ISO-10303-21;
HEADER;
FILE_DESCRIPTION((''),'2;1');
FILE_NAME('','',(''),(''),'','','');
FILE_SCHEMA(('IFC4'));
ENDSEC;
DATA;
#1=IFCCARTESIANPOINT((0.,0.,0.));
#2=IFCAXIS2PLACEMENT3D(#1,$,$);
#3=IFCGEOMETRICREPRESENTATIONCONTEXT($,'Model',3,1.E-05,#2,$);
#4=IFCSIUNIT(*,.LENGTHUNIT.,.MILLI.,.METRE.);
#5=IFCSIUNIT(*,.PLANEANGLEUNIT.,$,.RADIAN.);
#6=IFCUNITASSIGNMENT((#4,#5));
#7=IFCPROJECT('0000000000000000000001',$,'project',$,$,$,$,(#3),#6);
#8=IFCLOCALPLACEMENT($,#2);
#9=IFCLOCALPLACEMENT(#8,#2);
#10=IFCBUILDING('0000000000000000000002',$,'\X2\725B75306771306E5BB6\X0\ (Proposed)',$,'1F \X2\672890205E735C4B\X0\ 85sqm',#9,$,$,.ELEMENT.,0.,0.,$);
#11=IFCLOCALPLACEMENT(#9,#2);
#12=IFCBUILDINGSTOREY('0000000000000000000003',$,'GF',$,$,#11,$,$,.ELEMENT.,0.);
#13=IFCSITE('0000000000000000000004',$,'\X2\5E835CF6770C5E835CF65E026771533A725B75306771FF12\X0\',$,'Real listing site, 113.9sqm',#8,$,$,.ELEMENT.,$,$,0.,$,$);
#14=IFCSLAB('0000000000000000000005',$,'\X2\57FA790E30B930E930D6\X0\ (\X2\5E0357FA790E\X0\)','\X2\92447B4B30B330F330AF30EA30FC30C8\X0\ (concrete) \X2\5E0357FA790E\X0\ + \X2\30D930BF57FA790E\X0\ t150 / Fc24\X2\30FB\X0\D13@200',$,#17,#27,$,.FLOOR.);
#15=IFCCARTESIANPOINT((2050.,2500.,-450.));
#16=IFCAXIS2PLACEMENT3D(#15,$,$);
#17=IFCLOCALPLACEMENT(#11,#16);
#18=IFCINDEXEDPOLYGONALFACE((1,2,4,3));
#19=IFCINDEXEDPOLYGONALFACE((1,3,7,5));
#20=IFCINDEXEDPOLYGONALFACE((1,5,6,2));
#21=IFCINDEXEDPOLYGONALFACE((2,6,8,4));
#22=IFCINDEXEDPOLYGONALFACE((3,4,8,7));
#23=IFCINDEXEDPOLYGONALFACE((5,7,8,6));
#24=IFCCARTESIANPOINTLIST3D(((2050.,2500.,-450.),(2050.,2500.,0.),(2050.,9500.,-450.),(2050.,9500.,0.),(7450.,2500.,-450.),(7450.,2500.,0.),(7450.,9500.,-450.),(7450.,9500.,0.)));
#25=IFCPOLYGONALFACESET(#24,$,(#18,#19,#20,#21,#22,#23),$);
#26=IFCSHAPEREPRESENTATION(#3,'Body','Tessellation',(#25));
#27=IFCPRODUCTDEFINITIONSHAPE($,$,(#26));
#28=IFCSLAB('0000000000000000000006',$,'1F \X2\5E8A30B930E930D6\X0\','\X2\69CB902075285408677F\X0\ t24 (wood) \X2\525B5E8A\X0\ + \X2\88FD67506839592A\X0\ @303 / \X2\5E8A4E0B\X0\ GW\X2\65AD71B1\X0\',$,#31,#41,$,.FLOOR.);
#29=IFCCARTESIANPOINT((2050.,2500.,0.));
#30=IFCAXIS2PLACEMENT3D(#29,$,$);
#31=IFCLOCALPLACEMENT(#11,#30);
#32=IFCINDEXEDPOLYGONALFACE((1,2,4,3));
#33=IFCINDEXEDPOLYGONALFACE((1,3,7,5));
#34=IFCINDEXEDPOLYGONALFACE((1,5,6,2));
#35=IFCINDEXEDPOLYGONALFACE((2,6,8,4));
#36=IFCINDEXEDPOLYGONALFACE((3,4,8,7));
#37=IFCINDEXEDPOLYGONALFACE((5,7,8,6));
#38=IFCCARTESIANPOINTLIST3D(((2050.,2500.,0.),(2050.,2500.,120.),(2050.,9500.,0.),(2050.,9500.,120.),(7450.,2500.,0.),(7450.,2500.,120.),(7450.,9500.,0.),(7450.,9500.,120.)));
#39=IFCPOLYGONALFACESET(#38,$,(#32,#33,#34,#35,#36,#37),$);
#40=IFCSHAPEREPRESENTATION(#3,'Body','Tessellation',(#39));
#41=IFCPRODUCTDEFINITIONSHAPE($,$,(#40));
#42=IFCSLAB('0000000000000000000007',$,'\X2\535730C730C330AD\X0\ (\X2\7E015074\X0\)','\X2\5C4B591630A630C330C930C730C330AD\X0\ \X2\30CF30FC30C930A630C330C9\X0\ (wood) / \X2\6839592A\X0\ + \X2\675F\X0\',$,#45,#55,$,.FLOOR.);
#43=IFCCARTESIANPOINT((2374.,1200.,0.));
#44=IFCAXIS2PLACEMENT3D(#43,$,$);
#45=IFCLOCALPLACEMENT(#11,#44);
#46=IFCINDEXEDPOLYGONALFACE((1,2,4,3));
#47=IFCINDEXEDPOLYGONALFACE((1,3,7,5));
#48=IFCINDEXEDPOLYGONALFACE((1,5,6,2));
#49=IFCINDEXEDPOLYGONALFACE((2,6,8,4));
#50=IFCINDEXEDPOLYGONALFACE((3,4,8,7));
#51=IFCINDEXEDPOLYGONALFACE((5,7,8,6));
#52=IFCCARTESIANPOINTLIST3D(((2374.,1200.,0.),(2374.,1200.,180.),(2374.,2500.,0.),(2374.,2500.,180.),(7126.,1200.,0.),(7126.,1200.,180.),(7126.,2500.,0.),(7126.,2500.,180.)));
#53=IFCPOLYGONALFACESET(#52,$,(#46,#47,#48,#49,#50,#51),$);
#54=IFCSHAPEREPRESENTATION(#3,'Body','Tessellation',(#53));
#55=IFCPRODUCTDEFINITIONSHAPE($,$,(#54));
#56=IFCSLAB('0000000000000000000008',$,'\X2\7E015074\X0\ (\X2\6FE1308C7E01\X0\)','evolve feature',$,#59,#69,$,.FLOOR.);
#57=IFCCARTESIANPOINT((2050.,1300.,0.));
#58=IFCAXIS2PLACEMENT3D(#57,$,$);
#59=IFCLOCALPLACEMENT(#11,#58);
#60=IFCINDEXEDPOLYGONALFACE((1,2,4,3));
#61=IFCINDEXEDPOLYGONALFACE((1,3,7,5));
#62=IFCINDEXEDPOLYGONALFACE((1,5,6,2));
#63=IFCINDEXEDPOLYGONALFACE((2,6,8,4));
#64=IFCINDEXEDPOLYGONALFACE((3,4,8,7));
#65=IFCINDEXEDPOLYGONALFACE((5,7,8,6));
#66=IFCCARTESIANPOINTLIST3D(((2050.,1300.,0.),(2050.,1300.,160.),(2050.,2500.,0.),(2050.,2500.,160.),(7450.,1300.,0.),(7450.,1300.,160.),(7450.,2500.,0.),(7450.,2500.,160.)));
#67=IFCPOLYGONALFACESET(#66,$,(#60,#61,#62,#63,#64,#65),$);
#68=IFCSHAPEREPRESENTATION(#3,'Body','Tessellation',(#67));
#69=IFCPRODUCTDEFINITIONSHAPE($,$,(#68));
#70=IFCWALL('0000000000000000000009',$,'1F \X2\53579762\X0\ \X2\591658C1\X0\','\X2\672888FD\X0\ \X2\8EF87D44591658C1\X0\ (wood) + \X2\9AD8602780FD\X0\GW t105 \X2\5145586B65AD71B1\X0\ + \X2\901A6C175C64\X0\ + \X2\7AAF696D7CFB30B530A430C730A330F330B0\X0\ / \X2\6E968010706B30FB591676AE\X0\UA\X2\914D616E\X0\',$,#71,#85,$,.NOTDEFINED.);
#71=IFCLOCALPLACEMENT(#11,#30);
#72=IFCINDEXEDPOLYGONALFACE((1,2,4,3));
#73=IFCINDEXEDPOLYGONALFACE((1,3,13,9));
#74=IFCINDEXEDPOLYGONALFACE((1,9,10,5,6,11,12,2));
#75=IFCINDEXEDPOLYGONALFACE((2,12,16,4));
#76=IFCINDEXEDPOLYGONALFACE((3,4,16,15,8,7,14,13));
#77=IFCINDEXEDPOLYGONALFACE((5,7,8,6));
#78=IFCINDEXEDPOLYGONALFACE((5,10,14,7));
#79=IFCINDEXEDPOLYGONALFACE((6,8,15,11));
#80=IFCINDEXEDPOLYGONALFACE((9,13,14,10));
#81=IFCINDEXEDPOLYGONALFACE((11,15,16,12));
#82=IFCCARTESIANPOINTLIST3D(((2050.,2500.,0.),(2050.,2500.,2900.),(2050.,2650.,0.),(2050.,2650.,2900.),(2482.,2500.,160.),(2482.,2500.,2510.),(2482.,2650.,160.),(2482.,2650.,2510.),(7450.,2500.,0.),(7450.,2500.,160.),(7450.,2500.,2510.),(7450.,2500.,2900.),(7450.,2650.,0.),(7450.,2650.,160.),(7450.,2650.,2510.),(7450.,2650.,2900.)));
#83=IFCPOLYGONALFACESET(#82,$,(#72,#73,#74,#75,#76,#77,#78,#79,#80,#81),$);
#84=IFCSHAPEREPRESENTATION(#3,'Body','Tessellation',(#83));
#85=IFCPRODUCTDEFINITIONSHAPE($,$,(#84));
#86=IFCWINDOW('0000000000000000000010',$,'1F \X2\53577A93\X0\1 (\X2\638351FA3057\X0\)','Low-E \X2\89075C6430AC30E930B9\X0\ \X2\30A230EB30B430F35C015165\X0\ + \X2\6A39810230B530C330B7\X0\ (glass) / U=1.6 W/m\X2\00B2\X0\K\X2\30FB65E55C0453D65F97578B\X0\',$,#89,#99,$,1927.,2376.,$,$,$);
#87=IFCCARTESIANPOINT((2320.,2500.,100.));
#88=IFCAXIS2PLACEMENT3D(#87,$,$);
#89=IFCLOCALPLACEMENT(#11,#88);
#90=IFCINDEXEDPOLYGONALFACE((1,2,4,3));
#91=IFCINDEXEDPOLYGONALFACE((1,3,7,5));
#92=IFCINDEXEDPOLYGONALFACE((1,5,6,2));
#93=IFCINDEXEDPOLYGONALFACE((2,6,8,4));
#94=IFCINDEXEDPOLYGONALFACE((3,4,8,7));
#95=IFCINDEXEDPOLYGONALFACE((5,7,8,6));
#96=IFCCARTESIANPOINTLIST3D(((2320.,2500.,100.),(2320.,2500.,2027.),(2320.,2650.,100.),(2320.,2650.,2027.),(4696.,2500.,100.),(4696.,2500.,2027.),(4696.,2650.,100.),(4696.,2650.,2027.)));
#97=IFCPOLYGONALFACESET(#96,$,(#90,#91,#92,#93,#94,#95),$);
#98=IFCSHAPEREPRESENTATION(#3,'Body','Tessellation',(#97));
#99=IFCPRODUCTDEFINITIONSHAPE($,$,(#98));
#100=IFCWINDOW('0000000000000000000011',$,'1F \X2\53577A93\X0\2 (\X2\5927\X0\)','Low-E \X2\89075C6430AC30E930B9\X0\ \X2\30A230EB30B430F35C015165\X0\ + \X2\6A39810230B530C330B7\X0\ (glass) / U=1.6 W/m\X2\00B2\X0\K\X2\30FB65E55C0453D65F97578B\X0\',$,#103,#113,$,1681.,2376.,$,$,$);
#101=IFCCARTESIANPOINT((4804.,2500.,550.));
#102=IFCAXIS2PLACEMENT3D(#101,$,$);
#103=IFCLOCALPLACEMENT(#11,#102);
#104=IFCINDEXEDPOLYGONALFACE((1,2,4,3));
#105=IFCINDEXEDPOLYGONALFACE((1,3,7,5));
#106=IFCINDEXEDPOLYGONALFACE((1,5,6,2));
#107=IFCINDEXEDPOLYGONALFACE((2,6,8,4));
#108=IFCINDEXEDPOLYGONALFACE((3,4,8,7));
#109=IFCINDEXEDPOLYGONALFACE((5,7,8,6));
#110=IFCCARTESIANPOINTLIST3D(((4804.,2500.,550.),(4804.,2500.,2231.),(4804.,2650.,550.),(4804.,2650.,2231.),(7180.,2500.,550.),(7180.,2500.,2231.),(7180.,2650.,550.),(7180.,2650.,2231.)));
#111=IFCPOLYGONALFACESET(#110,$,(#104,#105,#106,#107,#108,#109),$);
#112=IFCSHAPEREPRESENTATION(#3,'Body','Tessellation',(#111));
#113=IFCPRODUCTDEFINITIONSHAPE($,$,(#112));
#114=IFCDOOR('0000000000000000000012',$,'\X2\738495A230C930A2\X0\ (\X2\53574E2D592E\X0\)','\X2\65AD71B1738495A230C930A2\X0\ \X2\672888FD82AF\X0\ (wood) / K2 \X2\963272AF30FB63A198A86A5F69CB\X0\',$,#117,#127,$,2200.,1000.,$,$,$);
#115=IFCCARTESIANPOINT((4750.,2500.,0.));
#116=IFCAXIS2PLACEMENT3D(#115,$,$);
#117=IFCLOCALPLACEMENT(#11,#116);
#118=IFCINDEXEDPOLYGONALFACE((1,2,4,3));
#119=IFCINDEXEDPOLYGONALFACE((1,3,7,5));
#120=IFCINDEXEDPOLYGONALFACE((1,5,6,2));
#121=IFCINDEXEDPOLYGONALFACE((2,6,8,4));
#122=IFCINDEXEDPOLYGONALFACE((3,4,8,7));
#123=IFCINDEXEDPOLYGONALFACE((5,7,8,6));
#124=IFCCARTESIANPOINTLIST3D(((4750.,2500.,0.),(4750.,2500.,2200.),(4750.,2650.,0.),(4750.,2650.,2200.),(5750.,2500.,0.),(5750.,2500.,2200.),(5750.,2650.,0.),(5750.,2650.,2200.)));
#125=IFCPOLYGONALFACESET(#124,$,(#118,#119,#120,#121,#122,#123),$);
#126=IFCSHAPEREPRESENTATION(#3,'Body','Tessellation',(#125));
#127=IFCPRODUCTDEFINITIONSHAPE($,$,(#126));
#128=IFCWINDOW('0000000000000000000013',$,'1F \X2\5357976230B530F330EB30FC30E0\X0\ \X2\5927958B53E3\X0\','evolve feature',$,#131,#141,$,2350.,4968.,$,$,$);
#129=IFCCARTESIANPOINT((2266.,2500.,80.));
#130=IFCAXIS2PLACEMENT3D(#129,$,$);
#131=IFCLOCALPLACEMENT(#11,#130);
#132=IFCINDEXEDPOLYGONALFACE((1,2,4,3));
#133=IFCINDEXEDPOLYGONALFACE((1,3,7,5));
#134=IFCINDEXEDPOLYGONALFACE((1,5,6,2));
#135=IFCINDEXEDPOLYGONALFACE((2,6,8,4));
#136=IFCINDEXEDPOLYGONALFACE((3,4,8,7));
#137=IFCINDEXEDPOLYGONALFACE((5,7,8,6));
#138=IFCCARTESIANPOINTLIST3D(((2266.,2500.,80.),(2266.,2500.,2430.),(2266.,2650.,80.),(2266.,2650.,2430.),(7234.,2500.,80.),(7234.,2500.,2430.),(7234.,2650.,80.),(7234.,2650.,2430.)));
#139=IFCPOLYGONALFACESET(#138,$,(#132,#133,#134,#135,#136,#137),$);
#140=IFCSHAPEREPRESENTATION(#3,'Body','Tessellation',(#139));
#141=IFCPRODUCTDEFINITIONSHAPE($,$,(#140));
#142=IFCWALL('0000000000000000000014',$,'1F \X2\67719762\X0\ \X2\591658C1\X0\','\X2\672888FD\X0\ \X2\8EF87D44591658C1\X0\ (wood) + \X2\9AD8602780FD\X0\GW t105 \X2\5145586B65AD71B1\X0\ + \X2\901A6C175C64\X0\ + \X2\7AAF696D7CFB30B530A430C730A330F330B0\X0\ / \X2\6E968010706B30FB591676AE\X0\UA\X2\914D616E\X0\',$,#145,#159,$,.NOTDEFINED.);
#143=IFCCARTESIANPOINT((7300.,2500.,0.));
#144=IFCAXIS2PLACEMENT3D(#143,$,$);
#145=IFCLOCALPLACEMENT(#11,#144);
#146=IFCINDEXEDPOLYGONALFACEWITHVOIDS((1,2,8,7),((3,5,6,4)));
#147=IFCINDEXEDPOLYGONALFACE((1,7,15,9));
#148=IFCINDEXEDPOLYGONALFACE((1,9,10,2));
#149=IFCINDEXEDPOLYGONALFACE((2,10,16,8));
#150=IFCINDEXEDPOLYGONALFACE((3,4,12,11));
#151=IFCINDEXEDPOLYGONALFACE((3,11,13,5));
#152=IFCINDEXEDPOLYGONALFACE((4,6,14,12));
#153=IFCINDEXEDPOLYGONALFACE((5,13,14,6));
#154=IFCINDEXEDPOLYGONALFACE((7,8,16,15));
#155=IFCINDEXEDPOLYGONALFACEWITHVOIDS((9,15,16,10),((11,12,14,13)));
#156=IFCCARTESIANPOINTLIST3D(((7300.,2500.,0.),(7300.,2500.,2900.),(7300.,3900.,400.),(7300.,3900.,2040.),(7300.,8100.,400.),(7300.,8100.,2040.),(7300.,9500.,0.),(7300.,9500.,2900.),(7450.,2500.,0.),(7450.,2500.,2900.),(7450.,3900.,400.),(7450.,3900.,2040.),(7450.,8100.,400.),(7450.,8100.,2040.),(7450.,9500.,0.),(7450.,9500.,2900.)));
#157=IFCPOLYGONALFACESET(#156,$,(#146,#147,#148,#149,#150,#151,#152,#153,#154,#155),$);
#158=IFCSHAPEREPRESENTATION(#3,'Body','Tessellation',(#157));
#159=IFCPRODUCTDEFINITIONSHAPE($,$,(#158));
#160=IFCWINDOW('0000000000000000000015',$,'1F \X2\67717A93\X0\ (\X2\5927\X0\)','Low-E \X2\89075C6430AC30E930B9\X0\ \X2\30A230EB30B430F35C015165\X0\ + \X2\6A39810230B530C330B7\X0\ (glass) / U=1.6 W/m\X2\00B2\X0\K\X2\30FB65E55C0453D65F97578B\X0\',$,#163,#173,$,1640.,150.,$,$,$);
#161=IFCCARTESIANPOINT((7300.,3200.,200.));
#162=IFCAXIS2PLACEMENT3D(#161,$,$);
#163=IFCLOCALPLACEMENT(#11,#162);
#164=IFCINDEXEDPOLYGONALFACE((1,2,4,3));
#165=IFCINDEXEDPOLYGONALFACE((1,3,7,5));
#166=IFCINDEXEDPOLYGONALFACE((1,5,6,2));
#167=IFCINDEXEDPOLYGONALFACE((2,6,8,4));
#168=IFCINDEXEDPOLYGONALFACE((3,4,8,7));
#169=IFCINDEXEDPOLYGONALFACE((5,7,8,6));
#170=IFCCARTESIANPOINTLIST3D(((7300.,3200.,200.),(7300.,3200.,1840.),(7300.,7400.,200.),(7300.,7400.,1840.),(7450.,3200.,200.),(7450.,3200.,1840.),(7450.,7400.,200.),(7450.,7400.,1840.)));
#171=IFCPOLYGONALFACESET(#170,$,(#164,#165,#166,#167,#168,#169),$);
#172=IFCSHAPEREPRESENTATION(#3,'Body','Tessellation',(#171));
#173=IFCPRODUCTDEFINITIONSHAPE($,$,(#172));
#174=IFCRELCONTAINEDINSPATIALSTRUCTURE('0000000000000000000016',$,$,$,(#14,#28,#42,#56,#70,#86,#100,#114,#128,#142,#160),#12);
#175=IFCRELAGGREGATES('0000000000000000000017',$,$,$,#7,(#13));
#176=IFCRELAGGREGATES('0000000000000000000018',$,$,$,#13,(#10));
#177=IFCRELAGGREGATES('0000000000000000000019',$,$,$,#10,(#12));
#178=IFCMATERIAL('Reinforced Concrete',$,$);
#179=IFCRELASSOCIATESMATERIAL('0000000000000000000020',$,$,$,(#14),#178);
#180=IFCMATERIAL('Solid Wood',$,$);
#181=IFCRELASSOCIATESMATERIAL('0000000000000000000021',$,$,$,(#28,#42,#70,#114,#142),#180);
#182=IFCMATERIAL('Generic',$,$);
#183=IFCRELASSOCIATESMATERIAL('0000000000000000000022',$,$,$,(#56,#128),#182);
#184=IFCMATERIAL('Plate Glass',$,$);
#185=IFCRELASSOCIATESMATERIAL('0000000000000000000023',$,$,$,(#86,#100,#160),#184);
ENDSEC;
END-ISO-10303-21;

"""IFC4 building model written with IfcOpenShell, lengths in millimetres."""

from ifc_helpers import new_model, si_unit, frame, frame_2d, origin, place, context, project, spatial, rectangle, extrude, material, element, fill, save


model = new_model("IFC4")

# Units and contexts
model_context = context("Model", 3, precision=1e-05, world=origin())
ifc_project = project(units=[si_unit("LENGTHUNIT", "METRE", prefix="MILLI"), si_unit("PLANEANGLEUNIT", "RADIAN")], contexts=[model_context])

# Site, building, storey
site_placement = place(None, origin())
site = spatial("IfcSite", under=ifc_project, at=site_placement, Name="広島県広島市東区牛田東２", ObjectType="Real listing site, 113.9sqm", CompositionType="ELEMENT", RefElevation=0.0)
building_placement = place(site_placement, origin())
building = spatial("IfcBuilding", under=site, at=building_placement, Name="牛田東の家 (Proposed)", ObjectType="1F 木造平屋 85sqm", CompositionType="ELEMENT", ElevationOfRefHeight=0.0, ElevationOfTerrain=0.0)
storey_placement = place(building_placement, origin())
storey = spatial("IfcBuildingStorey", under=building, at=storey_placement, Name="GF", CompositionType="ELEMENT", Elevation=0.0)

# Slabs
ifc_material_1 = material(Name="Reinforced Concrete")
slab_1_placement = place(storey_placement, frame((2050.0, 2500.0, -450.0)))
element("IfcSlab", 1, at=slab_1_placement, inside=storey, material=ifc_material_1, Name="基礎スラブ (布基礎)", Description="鉄筋コンクリート (concrete) 布基礎 + ベタ基礎 t150 / Fc24・D13@200", PredefinedType="FLOOR", context=model_context, shape_type="SweptSolid", body=[
    extrude(rectangle(XDim=5400.0, YDim=7000.0, at=frame_2d((2700.0, 3500.0))), frame((2050.0, 2500.0, -450.0)), (0.0, 0.0, 1.0), 450.0),
])
ifc_material_2 = material(Name="Solid Wood")
slab_2_placement = place(storey_placement, frame((2050.0, 2500.0, 0.0)))
element("IfcSlab", 2, at=slab_2_placement, inside=storey, material=ifc_material_2, Name="1F 床スラブ", Description="構造用合板 t24 (wood) 剛床 + 製材根太 @303 / 床下 GW断熱", PredefinedType="FLOOR", context=model_context, shape_type="SweptSolid", body=[
    extrude(rectangle(XDim=5400.0, YDim=7000.0, at=frame_2d((2700.0, 3500.0))), frame((2050.0, 2500.0, 0.0)), (0.0, 0.0, 1.0), 120.0),
])
slab_3_placement = place(storey_placement, frame((2374.0, 1200.0, 0.0)))
element("IfcSlab", 3, at=slab_3_placement, inside=storey, material=ifc_material_2, Name="南デッキ (縁側)", Description="屋外ウッドデッキ ハードウッド (wood) / 根太 + 束", PredefinedType="FLOOR", context=model_context, shape_type="SweptSolid", body=[
    extrude(rectangle(XDim=4752.0, YDim=1300.0, at=frame_2d((2376.0, 650.0))), frame((2374.0, 1200.0, 0.0)), (0.0, 0.0, 1.0), 180.0),
])
ifc_material_3 = material(Name="Generic")
slab_4_placement = place(storey_placement, frame((2050.0, 1300.0, 0.0)))
element("IfcSlab", 4, at=slab_4_placement, inside=storey, material=ifc_material_3, Name="縁側 (濡れ縁)", Description="evolve feature", PredefinedType="FLOOR", context=model_context, shape_type="SweptSolid", body=[
    extrude(rectangle(XDim=5400.0, YDim=1200.0, at=frame_2d((2700.0, 600.0))), frame((2050.0, 1300.0, 0.0)), (0.0, 0.0, 1.0), 160.0),
])

# Wall, openings, windows, door
wall_1_placement = place(storey_placement, frame((2050.0, 2500.0, 0.0)))
wall_1 = element("IfcWall", 5, at=wall_1_placement, inside=storey, material=ifc_material_2, Name="1F 南面 外壁", Description="木製 軸組外壁 (wood) + 高性能GW t105 充填断熱 + 通気層 + 窯業系サイディング / 準耐火・外皮UA配慮", PredefinedType="NOTDEFINED", context=model_context, shape_type="SweptSolid", body=[
    extrude(rectangle(XDim=5400.0, YDim=150.0, at=frame_2d((2700.0, 75.0))), frame((2050.0, 2500.0, 0.0)), (0.0, 0.0, 1.0), 2900.0),
])
opening_1_placement = place(storey_placement, frame((2320.0, 2500.0, 100.0)))
opening_1 = element("IfcOpeningElement", 6, at=opening_1_placement, cuts=wall_1, PredefinedType="NOTDEFINED", context=model_context, shape_type="SweptSolid", body=[
    extrude(rectangle(XDim=2376.0, YDim=150.0, at=frame_2d((1188.0, 75.0))), frame((2320.0, 2500.0, 100.0)), (0.0, 0.0, 1.0), 1927.0),
])
opening_2_placement = place(storey_placement, frame((4804.0, 2500.0, 550.0)))
opening_2 = element("IfcOpeningElement", 7, at=opening_2_placement, cuts=wall_1, PredefinedType="NOTDEFINED", context=model_context, shape_type="SweptSolid", body=[
    extrude(rectangle(XDim=2376.0, YDim=150.0, at=frame_2d((1188.0, 75.0))), frame((4804.0, 2500.0, 550.0)), (0.0, 0.0, 1.0), 1681.0),
])
opening_3_placement = place(storey_placement, frame((4750.0, 2500.0, 0.0)))
opening_3 = element("IfcOpeningElement", 8, at=opening_3_placement, cuts=wall_1, PredefinedType="NOTDEFINED", context=model_context, shape_type="SweptSolid", body=[
    extrude(rectangle(XDim=1000.0, YDim=150.0, at=frame_2d((500.0, 75.0))), frame((4750.0, 2500.0, 0.0)), (0.0, 0.0, 1.0), 2200.0),
])
opening_4_placement = place(storey_placement, frame((2266.0, 2500.0, 80.0)))
opening_4 = element("IfcOpeningElement", 9, at=opening_4_placement, cuts=wall_1, PredefinedType="NOTDEFINED", context=model_context, shape_type="SweptSolid", body=[
    extrude(rectangle(XDim=4968.0, YDim=150.0, at=frame_2d((2484.0, 75.0))), frame((2266.0, 2500.0, 80.0)), (0.0, 0.0, 1.0), 2350.0),
])
ifc_material_4 = material(Name="Plate Glass")
window_1_placement = place(storey_placement, frame((2320.0, 2500.0, 100.0)))
window_1 = element("IfcWindow", 10, at=window_1_placement, inside=storey, material=ifc_material_4, Name="1F 南窓1 (掃出し)", Description="Low-E 複層ガラス アルゴン封入 + 樹脂サッシ (glass) / U=1.6 W/m²K・日射取得型", OverallHeight=1927.0, OverallWidth=2376.0, context=model_context, shape_type="SweptSolid", body=[
    extrude(rectangle(XDim=2376.0, YDim=150.0, at=frame_2d((1188.0, 75.0))), frame((2320.0, 2500.0, 100.0)), (0.0, 0.0, 1.0), 1927.0),
])
fill(opening_1, window_1)
window_2_placement = place(storey_placement, frame((4804.0, 2500.0, 550.0)))
window_2 = element("IfcWindow", 11, at=window_2_placement, inside=storey, material=ifc_material_4, Name="1F 南窓2 (大)", Description="Low-E 複層ガラス アルゴン封入 + 樹脂サッシ (glass) / U=1.6 W/m²K・日射取得型", OverallHeight=1681.0, OverallWidth=2376.0, context=model_context, shape_type="SweptSolid", body=[
    extrude(rectangle(XDim=2376.0, YDim=150.0, at=frame_2d((1188.0, 75.0))), frame((4804.0, 2500.0, 550.0)), (0.0, 0.0, 1.0), 1681.0),
])
fill(opening_2, window_2)
door_placement = place(storey_placement, frame((4750.0, 2500.0, 0.0)))
door = element("IfcDoor", 12, at=door_placement, inside=storey, material=ifc_material_2, Name="玄関ドア (南中央)", Description="断熱玄関ドア 木製芯 (wood) / K2 防犯・採風機構", OverallHeight=2200.0, OverallWidth=1000.0, context=model_context, shape_type="SweptSolid", body=[
    extrude(rectangle(XDim=1000.0, YDim=150.0, at=frame_2d((500.0, 75.0))), frame((4750.0, 2500.0, 0.0)), (0.0, 0.0, 1.0), 2200.0),
])
fill(opening_3, door)
window_3_placement = place(storey_placement, frame((2266.0, 2500.0, 80.0)))
window_3 = element("IfcWindow", 13, at=window_3_placement, inside=storey, material=ifc_material_3, Name="1F 南面サンルーム 大開口", Description="evolve feature", OverallHeight=2350.0, OverallWidth=4968.0, context=model_context, shape_type="SweptSolid", body=[
    extrude(rectangle(XDim=4968.0, YDim=150.0, at=frame_2d((2484.0, 75.0))), frame((2266.0, 2500.0, 80.0)), (0.0, 0.0, 1.0), 2350.0),
])
fill(opening_4, window_3)

# Wall, opening, window
wall_2_placement = place(storey_placement, frame((7300.0, 2500.0, 0.0)))
wall_2 = element("IfcWall", 14, at=wall_2_placement, inside=storey, material=ifc_material_2, Name="1F 東面 外壁", Description="木製 軸組外壁 (wood) + 高性能GW t105 充填断熱 + 通気層 + 窯業系サイディング / 準耐火・外皮UA配慮", PredefinedType="NOTDEFINED", context=model_context, shape_type="SweptSolid", body=[
    extrude(rectangle(XDim=150.0, YDim=7000.0, at=frame_2d((75.0, 3500.0))), frame((7300.0, 2500.0, 0.0)), (0.0, 0.0, 1.0), 2900.0),
])
opening_5_placement = place(storey_placement, frame((7300.0, 3200.0, 200.0)))
opening_5 = element("IfcOpeningElement", 15, at=opening_5_placement, cuts=wall_2, PredefinedType="NOTDEFINED", context=model_context, shape_type="SweptSolid", body=[
    extrude(rectangle(XDim=150.0, YDim=4200.0, at=frame_2d((75.0, 2100.0))), frame((7300.0, 3200.0, 200.0)), (0.0, 0.0, 1.0), 1640.0),
])
window_4_placement = place(storey_placement, frame((7300.0, 3200.0, 200.0)))
window_4 = element("IfcWindow", 16, at=window_4_placement, inside=storey, material=ifc_material_4, Name="1F 東窓 (大)", Description="Low-E 複層ガラス アルゴン封入 + 樹脂サッシ (glass) / U=1.6 W/m²K・日射取得型", OverallHeight=1640.0, OverallWidth=150.0, context=model_context, shape_type="SweptSolid", body=[
    extrude(rectangle(XDim=150.0, YDim=4200.0, at=frame_2d((75.0, 2100.0))), frame((7300.0, 3200.0, 200.0)), (0.0, 0.0, 1.0), 1640.0),
])
fill(opening_5, window_4)

save(model, "model.ifc")
